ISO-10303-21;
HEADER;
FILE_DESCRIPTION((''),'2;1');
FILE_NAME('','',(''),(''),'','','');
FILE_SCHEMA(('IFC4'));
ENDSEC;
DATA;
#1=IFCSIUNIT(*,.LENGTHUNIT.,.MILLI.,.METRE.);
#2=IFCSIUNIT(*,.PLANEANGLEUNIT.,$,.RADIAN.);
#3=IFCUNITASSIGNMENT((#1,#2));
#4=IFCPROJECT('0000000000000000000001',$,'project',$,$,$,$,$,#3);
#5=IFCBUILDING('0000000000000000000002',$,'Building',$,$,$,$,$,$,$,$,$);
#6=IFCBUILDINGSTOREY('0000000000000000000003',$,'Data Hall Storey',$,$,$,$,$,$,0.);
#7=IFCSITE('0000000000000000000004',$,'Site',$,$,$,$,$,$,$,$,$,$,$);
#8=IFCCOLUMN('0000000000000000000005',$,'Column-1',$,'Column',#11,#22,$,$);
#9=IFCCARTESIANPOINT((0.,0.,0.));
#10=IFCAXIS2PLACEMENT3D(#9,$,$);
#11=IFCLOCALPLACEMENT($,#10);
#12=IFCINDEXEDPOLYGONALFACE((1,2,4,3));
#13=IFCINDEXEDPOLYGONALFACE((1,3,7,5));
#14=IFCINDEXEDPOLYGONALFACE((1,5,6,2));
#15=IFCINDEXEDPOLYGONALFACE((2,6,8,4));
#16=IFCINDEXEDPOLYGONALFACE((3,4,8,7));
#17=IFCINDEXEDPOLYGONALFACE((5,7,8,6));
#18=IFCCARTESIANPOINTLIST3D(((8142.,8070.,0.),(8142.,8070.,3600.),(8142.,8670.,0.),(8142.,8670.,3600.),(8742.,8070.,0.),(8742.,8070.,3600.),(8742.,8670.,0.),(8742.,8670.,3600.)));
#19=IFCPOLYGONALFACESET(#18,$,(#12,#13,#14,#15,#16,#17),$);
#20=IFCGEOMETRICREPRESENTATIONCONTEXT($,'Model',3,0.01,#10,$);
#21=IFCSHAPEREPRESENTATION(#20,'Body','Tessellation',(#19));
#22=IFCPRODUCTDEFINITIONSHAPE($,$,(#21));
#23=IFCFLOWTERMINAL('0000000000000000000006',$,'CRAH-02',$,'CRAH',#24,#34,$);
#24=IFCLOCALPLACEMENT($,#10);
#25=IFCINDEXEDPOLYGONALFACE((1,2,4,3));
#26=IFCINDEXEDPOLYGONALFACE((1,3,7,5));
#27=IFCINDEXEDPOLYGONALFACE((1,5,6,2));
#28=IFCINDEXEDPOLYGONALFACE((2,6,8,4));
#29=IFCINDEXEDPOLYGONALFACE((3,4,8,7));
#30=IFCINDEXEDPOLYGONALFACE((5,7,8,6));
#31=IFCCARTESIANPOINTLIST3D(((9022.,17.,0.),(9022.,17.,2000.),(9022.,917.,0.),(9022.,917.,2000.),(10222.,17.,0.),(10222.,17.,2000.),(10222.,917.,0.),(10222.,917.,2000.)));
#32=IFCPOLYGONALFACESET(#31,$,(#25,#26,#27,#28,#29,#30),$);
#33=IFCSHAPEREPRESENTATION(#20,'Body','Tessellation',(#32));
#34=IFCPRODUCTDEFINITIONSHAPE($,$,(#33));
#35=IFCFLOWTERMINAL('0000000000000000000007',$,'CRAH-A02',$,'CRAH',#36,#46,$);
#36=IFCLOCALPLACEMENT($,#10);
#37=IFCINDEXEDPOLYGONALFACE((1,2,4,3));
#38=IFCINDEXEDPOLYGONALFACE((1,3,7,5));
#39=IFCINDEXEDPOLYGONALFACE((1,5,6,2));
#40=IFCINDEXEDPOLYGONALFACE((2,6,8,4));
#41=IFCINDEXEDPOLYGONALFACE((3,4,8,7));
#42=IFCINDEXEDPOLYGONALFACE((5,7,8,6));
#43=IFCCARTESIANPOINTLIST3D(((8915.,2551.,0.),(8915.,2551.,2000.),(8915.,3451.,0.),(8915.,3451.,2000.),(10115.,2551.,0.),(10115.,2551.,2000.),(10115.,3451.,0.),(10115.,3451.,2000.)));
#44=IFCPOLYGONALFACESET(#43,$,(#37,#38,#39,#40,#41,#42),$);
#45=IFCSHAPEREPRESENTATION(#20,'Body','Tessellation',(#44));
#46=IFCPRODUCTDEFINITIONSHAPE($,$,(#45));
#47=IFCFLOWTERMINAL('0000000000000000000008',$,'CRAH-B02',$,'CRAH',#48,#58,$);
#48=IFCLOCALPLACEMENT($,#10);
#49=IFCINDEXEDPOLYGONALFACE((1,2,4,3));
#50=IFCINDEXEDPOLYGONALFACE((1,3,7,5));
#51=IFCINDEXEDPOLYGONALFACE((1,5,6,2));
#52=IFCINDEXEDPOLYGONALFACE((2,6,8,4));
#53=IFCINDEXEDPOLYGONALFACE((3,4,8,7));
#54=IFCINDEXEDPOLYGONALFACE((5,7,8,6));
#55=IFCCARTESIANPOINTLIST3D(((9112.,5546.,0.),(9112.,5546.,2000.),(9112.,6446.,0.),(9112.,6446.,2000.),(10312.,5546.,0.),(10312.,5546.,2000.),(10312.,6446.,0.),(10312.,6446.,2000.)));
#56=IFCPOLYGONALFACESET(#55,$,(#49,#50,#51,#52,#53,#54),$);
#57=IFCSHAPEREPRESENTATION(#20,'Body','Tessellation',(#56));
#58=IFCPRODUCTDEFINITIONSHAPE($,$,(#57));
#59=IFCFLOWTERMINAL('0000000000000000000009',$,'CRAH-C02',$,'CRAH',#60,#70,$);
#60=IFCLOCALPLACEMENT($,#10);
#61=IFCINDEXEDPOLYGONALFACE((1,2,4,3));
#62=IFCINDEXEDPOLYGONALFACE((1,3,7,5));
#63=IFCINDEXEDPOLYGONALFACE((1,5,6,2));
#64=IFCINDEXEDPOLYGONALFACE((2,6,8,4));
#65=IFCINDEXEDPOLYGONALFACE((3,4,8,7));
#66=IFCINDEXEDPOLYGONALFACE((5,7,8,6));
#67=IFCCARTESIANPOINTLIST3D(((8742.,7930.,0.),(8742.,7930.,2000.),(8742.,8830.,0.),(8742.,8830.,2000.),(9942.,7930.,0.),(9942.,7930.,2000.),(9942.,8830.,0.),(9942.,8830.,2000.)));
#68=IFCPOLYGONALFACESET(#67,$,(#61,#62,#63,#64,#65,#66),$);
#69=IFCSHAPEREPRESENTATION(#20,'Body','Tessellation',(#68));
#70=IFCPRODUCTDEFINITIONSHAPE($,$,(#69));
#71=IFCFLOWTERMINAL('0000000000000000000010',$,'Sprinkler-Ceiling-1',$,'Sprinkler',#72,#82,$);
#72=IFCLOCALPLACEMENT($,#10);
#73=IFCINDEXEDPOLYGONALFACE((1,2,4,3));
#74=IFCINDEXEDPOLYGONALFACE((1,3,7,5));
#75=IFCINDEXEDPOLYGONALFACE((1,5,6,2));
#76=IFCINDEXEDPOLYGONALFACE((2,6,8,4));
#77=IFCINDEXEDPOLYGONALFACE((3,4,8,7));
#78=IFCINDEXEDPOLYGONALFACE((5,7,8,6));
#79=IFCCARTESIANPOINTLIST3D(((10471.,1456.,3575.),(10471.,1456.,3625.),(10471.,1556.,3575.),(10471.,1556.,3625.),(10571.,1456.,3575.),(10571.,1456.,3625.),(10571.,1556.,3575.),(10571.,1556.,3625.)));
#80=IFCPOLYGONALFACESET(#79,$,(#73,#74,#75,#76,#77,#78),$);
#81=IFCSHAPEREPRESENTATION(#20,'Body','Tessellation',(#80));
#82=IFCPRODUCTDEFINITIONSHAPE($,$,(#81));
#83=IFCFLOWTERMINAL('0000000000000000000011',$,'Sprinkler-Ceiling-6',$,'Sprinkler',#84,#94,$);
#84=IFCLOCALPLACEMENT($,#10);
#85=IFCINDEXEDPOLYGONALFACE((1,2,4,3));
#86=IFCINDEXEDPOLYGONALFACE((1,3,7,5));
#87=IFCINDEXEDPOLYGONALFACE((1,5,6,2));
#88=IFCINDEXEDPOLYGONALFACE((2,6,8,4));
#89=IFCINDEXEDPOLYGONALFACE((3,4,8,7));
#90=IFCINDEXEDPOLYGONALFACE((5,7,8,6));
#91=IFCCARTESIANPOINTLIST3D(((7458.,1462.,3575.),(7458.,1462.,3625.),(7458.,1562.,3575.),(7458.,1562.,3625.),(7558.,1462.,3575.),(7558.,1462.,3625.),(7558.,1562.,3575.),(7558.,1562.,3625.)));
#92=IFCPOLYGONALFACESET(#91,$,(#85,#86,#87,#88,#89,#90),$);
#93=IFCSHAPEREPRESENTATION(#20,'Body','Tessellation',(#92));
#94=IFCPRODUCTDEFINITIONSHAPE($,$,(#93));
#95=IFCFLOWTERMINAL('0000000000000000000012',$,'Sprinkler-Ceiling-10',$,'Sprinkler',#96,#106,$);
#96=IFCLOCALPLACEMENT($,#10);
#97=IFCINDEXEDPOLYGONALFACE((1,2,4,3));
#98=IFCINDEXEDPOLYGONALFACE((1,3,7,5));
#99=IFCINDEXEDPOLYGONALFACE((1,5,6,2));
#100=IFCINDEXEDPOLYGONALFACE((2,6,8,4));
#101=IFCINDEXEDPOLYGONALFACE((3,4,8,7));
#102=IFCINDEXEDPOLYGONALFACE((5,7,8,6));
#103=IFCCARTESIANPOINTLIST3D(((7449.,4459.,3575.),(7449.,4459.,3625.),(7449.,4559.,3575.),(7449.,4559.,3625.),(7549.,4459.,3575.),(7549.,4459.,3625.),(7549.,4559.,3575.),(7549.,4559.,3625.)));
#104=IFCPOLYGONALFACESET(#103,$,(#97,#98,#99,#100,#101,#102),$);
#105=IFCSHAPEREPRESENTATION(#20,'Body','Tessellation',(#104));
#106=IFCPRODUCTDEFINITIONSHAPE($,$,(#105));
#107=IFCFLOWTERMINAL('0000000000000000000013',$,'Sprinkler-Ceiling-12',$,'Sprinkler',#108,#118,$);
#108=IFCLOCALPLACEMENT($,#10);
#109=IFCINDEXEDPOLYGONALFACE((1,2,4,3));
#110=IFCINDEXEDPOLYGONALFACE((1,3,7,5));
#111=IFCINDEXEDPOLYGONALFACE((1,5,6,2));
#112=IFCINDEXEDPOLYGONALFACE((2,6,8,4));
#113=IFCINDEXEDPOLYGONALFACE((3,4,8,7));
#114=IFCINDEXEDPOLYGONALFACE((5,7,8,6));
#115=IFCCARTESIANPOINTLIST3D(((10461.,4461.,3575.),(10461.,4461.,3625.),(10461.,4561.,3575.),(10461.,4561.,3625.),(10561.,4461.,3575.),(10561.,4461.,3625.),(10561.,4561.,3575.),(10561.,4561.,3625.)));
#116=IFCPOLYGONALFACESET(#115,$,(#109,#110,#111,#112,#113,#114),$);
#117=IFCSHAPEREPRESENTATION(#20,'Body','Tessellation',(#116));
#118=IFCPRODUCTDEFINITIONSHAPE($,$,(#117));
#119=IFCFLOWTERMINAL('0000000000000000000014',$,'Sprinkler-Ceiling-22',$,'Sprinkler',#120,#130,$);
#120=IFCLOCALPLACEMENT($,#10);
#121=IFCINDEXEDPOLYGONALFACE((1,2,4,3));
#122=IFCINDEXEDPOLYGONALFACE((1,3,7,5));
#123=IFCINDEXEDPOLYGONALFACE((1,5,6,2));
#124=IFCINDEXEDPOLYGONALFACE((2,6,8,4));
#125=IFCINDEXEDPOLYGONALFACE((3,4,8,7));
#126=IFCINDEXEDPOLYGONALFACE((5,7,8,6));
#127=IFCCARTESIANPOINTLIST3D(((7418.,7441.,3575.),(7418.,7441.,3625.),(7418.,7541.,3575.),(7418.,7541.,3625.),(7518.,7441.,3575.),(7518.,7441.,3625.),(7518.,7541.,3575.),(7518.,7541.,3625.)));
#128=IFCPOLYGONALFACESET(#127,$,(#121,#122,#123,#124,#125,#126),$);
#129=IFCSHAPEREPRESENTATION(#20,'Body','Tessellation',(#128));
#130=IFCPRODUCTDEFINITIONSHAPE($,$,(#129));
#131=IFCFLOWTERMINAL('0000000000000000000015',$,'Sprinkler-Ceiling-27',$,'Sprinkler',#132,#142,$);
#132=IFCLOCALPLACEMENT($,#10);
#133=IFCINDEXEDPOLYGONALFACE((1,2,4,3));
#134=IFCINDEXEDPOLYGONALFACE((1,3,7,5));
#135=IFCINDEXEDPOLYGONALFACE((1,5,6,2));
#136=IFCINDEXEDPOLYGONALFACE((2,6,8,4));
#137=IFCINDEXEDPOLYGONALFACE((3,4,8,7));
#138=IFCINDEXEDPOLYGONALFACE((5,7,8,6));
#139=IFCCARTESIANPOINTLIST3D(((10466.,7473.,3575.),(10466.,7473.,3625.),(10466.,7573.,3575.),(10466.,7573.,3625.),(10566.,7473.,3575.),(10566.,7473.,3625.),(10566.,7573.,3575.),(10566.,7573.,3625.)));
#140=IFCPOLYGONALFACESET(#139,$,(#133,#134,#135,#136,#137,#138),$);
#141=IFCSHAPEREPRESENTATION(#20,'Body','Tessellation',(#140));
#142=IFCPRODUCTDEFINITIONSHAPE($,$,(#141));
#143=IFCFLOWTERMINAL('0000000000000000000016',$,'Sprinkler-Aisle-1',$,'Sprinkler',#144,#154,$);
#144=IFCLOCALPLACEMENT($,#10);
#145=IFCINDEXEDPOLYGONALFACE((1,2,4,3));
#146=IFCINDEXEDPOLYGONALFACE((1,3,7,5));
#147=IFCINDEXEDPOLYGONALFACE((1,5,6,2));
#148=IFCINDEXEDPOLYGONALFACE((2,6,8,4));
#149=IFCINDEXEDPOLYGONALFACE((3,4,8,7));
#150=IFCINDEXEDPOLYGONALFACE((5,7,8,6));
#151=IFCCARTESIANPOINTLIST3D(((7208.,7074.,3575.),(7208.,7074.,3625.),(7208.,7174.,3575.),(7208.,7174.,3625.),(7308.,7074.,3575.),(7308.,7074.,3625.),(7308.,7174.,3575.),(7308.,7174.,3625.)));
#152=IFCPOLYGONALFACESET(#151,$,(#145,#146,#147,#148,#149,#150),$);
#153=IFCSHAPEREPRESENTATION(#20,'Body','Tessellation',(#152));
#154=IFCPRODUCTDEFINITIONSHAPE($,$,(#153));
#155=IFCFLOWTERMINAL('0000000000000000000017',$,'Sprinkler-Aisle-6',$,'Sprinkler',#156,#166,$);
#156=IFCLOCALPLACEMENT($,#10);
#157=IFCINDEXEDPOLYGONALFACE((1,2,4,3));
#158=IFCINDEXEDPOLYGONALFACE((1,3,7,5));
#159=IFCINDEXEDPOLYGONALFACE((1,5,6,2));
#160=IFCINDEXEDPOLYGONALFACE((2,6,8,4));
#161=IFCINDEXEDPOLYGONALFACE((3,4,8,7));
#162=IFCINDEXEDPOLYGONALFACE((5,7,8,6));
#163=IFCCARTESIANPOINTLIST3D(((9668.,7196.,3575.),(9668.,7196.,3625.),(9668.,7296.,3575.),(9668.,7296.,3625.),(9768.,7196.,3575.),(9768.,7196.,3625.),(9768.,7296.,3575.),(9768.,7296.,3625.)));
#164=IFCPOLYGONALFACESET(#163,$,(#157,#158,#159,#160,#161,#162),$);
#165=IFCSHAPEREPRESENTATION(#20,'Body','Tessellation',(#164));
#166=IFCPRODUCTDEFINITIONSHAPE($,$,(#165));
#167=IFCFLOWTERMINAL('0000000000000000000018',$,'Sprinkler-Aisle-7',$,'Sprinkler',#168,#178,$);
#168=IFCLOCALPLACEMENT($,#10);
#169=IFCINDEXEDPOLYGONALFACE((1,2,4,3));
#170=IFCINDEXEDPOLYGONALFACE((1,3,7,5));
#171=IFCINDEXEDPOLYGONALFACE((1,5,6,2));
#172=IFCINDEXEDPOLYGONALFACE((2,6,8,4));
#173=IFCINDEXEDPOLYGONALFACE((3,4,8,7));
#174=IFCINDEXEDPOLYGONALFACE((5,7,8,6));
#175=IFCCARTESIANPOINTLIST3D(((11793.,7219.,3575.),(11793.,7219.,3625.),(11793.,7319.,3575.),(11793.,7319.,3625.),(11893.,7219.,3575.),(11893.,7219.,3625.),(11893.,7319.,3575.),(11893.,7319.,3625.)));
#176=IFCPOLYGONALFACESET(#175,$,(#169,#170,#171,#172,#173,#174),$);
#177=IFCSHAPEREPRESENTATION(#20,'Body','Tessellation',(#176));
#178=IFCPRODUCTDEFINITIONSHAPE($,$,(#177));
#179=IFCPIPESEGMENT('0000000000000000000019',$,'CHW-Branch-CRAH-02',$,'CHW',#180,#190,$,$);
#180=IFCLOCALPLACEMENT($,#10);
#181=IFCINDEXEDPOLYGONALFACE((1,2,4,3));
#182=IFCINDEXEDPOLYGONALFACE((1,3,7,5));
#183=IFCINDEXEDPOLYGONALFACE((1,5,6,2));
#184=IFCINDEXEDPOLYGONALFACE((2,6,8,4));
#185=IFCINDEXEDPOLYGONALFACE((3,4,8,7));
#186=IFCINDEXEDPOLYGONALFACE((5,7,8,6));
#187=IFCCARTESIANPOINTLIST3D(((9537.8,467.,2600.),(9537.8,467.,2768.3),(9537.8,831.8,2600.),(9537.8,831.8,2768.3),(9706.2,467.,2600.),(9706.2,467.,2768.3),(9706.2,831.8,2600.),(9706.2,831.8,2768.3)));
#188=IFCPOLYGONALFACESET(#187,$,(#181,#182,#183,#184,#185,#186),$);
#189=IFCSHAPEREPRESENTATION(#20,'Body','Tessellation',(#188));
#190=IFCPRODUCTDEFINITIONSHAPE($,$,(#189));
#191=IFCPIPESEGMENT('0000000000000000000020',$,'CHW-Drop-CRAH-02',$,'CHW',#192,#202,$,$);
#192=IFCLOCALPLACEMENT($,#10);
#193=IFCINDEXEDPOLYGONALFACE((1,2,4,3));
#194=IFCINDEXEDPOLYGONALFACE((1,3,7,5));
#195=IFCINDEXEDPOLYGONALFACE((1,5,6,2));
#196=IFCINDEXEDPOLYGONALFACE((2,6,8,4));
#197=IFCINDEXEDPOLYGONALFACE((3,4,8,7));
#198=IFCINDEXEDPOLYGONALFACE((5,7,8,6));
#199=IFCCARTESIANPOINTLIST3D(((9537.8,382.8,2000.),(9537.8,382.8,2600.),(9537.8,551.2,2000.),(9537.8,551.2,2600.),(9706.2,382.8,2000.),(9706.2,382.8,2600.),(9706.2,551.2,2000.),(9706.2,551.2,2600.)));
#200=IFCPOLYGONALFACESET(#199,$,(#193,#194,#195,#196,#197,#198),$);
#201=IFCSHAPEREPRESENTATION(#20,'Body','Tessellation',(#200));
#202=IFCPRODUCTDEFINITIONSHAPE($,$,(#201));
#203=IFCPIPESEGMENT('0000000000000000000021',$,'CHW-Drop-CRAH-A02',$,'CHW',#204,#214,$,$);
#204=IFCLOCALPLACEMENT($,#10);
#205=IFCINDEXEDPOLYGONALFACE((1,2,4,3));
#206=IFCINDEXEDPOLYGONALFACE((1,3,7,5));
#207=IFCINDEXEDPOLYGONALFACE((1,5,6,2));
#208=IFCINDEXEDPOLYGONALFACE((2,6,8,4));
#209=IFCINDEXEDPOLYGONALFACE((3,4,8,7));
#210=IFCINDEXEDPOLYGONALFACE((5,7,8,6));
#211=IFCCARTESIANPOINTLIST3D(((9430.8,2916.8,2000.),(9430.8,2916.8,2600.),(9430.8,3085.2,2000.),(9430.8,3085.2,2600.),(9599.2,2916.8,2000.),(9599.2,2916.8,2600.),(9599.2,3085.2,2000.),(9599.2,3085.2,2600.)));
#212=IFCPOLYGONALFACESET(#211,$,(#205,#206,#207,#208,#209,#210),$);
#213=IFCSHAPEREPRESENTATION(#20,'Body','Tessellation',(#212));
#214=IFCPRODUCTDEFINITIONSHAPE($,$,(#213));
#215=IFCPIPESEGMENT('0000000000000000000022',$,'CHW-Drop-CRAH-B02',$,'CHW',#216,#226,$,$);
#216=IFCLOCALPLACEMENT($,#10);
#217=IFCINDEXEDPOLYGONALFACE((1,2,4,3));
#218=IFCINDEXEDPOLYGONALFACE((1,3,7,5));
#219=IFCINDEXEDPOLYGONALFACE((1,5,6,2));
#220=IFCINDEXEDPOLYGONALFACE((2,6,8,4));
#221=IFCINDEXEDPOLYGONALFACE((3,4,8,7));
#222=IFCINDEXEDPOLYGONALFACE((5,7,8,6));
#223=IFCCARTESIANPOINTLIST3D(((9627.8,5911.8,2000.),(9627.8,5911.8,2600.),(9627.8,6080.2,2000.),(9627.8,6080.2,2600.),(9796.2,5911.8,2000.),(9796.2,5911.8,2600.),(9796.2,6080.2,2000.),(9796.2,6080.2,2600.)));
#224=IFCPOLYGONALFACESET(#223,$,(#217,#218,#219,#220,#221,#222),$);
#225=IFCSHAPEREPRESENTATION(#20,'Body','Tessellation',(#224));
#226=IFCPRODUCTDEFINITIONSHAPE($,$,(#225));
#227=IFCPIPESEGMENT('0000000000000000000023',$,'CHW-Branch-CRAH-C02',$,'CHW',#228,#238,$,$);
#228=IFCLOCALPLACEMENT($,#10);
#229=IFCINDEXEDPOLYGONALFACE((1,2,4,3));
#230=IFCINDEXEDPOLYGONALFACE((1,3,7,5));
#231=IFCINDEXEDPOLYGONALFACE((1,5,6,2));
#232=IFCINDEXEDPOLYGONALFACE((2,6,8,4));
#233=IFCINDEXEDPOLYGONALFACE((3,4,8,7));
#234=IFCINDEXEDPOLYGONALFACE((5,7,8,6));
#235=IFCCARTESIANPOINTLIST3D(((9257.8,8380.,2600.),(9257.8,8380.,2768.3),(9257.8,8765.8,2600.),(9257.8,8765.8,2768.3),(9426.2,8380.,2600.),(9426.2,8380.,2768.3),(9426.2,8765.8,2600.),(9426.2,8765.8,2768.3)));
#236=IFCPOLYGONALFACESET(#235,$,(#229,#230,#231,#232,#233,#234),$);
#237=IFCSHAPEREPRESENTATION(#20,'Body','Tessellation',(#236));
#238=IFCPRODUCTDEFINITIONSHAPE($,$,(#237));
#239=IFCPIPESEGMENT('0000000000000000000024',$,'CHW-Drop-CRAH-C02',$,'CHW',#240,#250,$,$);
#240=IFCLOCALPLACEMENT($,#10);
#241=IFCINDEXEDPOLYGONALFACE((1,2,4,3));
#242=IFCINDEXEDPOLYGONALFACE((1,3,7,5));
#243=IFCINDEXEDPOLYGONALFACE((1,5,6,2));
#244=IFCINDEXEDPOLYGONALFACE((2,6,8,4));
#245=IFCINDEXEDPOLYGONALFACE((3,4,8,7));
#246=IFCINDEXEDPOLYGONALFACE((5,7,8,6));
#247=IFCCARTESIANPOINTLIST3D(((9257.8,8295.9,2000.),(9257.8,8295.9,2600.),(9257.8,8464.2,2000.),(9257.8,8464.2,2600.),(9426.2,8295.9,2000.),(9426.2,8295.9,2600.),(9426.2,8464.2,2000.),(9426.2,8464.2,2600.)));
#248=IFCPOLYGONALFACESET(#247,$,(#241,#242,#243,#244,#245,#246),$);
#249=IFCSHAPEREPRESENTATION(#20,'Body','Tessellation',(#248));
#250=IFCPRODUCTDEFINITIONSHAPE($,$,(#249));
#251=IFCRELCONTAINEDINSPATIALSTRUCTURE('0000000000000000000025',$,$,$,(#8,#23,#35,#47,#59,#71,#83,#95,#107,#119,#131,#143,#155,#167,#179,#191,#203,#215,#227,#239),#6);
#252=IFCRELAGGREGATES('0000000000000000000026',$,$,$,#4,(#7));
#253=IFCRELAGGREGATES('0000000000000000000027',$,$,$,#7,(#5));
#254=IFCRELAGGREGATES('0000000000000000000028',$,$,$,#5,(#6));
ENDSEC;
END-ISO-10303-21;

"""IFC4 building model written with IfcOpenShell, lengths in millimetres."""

from ifc_helpers import new_model, si_unit, frame, origin, place, context, project, spatial, rectangle, extrude, element, save


model = new_model("IFC4")

# Units and contexts
model_context = context("Model", 3, precision=0.01, world=origin())
ifc_project = project(units=[si_unit("LENGTHUNIT", "METRE", prefix="MILLI"), si_unit("PLANEANGLEUNIT", "RADIAN")])

# Site, building, storey
site = spatial("IfcSite", under=ifc_project, Name="Site")
building = spatial("IfcBuilding", under=site, Name="Building")
storey = spatial("IfcBuildingStorey", under=building, Name="Data Hall Storey", Elevation=0.0)

# Column
column_placement = place(None, frame((8442.0, 8370.0, 0.0)))
element("IfcColumn", 1, at=column_placement, inside=storey, Name="Column-1", ObjectType="Column", context=model_context, shape_type="SweptSolid", body=[
    extrude(rectangle(XDim=600.0, YDim=600.0), origin(), (0.0, 0.0, 1.0), 3600.0),
])

# Flow terminals
for number, where, name in (
    (2, (9622.0, 467.0, 0.0), "CRAH-02"),
    (3, (9515.0, 3001.0, 0.0), "CRAH-A02"),
    (4, (9712.0, 5996.0, 0.0), "CRAH-B02"),
    (5, (9342.0, 8380.0, 0.0), "CRAH-C02"),
):
    element("IfcFlowTerminal", number, at=place(None, frame(where)), inside=storey, Name=name, ObjectType="CRAH", context=model_context, shape_type="SweptSolid", body=[
        extrude(rectangle(XDim=1200.0, YDim=900.0), origin(), (0.0, 0.0, 1.0), 2000.0),
    ])
for number, where, name in (
    (6, (10521.0, 1506.0, 3575.0), "Sprinkler-Ceiling-1"),
    (7, (7508.0, 1512.0, 3575.0), "Sprinkler-Ceiling-6"),
    (8, (7499.0, 4509.0, 3575.0), "Sprinkler-Ceiling-10"),
    (9, (10511.0, 4511.0, 3575.0), "Sprinkler-Ceiling-12"),
    (10, (7468.0, 7491.0, 3575.0), "Sprinkler-Ceiling-22"),
    (11, (10516.0, 7523.0, 3575.0), "Sprinkler-Ceiling-27"),
    (12, (7258.0, 7124.0, 3575.0), "Sprinkler-Aisle-1"),
    (13, (9718.0, 7246.0, 3575.0), "Sprinkler-Aisle-6"),
    (14, (11843.0, 7269.0, 3575.0), "Sprinkler-Aisle-7"),
):
    element("IfcFlowTerminal", number, at=place(None, frame(where)), inside=storey, Name=name, ObjectType="Sprinkler", context=model_context, shape_type="SweptSolid", body=[
        extrude(rectangle(XDim=100.0, YDim=100.0), origin(), (0.0, 0.0, 1.0), 50.0),
    ])

# Pipe segments
pipe_segment_1_placement = place(None, frame((9622.0, 649.4, 2600.0)))
element("IfcPipeSegment", 15, at=pipe_segment_1_placement, inside=storey, Name="CHW-Branch-CRAH-02", ObjectType="CHW", context=model_context, shape_type="SweptSolid", body=[
    extrude(rectangle(XDim=168.3, YDim=364.9), origin(), (0.0, 0.0, 1.0), 168.3),
])
for number, where, name in (
    (16, (9622.0, 467.0, 2000.0), "CHW-Drop-CRAH-02"),
    (17, (9515.0, 3001.0, 2000.0), "CHW-Drop-CRAH-A02"),
    (18, (9712.0, 5996.0, 2000.0), "CHW-Drop-CRAH-B02"),
):
    element("IfcPipeSegment", number, at=place(None, frame(where)), inside=storey, Name=name, ObjectType="CHW", context=model_context, shape_type="SweptSolid", body=[
        extrude(rectangle(XDim=168.3, YDim=168.3), origin(), (0.0, 0.0, 1.0), 600.0),
    ])
pipe_segment_2_placement = place(None, frame((9342.0, 8572.9, 2600.0)))
element("IfcPipeSegment", 19, at=pipe_segment_2_placement, inside=storey, Name="CHW-Branch-CRAH-C02", ObjectType="CHW", context=model_context, shape_type="SweptSolid", body=[
    extrude(rectangle(XDim=168.3, YDim=385.9), origin(), (0.0, 0.0, 1.0), 168.3),
])
pipe_segment_3_placement = place(None, frame((9342.0, 8380.0, 2000.0)))
element("IfcPipeSegment", 20, at=pipe_segment_3_placement, inside=storey, Name="CHW-Drop-CRAH-C02", ObjectType="CHW", context=model_context, shape_type="SweptSolid", body=[
    extrude(rectangle(XDim=168.3, YDim=168.3), origin(), (0.0, 0.0, 1.0), 600.0),
])

save(model, "model.ifc")
